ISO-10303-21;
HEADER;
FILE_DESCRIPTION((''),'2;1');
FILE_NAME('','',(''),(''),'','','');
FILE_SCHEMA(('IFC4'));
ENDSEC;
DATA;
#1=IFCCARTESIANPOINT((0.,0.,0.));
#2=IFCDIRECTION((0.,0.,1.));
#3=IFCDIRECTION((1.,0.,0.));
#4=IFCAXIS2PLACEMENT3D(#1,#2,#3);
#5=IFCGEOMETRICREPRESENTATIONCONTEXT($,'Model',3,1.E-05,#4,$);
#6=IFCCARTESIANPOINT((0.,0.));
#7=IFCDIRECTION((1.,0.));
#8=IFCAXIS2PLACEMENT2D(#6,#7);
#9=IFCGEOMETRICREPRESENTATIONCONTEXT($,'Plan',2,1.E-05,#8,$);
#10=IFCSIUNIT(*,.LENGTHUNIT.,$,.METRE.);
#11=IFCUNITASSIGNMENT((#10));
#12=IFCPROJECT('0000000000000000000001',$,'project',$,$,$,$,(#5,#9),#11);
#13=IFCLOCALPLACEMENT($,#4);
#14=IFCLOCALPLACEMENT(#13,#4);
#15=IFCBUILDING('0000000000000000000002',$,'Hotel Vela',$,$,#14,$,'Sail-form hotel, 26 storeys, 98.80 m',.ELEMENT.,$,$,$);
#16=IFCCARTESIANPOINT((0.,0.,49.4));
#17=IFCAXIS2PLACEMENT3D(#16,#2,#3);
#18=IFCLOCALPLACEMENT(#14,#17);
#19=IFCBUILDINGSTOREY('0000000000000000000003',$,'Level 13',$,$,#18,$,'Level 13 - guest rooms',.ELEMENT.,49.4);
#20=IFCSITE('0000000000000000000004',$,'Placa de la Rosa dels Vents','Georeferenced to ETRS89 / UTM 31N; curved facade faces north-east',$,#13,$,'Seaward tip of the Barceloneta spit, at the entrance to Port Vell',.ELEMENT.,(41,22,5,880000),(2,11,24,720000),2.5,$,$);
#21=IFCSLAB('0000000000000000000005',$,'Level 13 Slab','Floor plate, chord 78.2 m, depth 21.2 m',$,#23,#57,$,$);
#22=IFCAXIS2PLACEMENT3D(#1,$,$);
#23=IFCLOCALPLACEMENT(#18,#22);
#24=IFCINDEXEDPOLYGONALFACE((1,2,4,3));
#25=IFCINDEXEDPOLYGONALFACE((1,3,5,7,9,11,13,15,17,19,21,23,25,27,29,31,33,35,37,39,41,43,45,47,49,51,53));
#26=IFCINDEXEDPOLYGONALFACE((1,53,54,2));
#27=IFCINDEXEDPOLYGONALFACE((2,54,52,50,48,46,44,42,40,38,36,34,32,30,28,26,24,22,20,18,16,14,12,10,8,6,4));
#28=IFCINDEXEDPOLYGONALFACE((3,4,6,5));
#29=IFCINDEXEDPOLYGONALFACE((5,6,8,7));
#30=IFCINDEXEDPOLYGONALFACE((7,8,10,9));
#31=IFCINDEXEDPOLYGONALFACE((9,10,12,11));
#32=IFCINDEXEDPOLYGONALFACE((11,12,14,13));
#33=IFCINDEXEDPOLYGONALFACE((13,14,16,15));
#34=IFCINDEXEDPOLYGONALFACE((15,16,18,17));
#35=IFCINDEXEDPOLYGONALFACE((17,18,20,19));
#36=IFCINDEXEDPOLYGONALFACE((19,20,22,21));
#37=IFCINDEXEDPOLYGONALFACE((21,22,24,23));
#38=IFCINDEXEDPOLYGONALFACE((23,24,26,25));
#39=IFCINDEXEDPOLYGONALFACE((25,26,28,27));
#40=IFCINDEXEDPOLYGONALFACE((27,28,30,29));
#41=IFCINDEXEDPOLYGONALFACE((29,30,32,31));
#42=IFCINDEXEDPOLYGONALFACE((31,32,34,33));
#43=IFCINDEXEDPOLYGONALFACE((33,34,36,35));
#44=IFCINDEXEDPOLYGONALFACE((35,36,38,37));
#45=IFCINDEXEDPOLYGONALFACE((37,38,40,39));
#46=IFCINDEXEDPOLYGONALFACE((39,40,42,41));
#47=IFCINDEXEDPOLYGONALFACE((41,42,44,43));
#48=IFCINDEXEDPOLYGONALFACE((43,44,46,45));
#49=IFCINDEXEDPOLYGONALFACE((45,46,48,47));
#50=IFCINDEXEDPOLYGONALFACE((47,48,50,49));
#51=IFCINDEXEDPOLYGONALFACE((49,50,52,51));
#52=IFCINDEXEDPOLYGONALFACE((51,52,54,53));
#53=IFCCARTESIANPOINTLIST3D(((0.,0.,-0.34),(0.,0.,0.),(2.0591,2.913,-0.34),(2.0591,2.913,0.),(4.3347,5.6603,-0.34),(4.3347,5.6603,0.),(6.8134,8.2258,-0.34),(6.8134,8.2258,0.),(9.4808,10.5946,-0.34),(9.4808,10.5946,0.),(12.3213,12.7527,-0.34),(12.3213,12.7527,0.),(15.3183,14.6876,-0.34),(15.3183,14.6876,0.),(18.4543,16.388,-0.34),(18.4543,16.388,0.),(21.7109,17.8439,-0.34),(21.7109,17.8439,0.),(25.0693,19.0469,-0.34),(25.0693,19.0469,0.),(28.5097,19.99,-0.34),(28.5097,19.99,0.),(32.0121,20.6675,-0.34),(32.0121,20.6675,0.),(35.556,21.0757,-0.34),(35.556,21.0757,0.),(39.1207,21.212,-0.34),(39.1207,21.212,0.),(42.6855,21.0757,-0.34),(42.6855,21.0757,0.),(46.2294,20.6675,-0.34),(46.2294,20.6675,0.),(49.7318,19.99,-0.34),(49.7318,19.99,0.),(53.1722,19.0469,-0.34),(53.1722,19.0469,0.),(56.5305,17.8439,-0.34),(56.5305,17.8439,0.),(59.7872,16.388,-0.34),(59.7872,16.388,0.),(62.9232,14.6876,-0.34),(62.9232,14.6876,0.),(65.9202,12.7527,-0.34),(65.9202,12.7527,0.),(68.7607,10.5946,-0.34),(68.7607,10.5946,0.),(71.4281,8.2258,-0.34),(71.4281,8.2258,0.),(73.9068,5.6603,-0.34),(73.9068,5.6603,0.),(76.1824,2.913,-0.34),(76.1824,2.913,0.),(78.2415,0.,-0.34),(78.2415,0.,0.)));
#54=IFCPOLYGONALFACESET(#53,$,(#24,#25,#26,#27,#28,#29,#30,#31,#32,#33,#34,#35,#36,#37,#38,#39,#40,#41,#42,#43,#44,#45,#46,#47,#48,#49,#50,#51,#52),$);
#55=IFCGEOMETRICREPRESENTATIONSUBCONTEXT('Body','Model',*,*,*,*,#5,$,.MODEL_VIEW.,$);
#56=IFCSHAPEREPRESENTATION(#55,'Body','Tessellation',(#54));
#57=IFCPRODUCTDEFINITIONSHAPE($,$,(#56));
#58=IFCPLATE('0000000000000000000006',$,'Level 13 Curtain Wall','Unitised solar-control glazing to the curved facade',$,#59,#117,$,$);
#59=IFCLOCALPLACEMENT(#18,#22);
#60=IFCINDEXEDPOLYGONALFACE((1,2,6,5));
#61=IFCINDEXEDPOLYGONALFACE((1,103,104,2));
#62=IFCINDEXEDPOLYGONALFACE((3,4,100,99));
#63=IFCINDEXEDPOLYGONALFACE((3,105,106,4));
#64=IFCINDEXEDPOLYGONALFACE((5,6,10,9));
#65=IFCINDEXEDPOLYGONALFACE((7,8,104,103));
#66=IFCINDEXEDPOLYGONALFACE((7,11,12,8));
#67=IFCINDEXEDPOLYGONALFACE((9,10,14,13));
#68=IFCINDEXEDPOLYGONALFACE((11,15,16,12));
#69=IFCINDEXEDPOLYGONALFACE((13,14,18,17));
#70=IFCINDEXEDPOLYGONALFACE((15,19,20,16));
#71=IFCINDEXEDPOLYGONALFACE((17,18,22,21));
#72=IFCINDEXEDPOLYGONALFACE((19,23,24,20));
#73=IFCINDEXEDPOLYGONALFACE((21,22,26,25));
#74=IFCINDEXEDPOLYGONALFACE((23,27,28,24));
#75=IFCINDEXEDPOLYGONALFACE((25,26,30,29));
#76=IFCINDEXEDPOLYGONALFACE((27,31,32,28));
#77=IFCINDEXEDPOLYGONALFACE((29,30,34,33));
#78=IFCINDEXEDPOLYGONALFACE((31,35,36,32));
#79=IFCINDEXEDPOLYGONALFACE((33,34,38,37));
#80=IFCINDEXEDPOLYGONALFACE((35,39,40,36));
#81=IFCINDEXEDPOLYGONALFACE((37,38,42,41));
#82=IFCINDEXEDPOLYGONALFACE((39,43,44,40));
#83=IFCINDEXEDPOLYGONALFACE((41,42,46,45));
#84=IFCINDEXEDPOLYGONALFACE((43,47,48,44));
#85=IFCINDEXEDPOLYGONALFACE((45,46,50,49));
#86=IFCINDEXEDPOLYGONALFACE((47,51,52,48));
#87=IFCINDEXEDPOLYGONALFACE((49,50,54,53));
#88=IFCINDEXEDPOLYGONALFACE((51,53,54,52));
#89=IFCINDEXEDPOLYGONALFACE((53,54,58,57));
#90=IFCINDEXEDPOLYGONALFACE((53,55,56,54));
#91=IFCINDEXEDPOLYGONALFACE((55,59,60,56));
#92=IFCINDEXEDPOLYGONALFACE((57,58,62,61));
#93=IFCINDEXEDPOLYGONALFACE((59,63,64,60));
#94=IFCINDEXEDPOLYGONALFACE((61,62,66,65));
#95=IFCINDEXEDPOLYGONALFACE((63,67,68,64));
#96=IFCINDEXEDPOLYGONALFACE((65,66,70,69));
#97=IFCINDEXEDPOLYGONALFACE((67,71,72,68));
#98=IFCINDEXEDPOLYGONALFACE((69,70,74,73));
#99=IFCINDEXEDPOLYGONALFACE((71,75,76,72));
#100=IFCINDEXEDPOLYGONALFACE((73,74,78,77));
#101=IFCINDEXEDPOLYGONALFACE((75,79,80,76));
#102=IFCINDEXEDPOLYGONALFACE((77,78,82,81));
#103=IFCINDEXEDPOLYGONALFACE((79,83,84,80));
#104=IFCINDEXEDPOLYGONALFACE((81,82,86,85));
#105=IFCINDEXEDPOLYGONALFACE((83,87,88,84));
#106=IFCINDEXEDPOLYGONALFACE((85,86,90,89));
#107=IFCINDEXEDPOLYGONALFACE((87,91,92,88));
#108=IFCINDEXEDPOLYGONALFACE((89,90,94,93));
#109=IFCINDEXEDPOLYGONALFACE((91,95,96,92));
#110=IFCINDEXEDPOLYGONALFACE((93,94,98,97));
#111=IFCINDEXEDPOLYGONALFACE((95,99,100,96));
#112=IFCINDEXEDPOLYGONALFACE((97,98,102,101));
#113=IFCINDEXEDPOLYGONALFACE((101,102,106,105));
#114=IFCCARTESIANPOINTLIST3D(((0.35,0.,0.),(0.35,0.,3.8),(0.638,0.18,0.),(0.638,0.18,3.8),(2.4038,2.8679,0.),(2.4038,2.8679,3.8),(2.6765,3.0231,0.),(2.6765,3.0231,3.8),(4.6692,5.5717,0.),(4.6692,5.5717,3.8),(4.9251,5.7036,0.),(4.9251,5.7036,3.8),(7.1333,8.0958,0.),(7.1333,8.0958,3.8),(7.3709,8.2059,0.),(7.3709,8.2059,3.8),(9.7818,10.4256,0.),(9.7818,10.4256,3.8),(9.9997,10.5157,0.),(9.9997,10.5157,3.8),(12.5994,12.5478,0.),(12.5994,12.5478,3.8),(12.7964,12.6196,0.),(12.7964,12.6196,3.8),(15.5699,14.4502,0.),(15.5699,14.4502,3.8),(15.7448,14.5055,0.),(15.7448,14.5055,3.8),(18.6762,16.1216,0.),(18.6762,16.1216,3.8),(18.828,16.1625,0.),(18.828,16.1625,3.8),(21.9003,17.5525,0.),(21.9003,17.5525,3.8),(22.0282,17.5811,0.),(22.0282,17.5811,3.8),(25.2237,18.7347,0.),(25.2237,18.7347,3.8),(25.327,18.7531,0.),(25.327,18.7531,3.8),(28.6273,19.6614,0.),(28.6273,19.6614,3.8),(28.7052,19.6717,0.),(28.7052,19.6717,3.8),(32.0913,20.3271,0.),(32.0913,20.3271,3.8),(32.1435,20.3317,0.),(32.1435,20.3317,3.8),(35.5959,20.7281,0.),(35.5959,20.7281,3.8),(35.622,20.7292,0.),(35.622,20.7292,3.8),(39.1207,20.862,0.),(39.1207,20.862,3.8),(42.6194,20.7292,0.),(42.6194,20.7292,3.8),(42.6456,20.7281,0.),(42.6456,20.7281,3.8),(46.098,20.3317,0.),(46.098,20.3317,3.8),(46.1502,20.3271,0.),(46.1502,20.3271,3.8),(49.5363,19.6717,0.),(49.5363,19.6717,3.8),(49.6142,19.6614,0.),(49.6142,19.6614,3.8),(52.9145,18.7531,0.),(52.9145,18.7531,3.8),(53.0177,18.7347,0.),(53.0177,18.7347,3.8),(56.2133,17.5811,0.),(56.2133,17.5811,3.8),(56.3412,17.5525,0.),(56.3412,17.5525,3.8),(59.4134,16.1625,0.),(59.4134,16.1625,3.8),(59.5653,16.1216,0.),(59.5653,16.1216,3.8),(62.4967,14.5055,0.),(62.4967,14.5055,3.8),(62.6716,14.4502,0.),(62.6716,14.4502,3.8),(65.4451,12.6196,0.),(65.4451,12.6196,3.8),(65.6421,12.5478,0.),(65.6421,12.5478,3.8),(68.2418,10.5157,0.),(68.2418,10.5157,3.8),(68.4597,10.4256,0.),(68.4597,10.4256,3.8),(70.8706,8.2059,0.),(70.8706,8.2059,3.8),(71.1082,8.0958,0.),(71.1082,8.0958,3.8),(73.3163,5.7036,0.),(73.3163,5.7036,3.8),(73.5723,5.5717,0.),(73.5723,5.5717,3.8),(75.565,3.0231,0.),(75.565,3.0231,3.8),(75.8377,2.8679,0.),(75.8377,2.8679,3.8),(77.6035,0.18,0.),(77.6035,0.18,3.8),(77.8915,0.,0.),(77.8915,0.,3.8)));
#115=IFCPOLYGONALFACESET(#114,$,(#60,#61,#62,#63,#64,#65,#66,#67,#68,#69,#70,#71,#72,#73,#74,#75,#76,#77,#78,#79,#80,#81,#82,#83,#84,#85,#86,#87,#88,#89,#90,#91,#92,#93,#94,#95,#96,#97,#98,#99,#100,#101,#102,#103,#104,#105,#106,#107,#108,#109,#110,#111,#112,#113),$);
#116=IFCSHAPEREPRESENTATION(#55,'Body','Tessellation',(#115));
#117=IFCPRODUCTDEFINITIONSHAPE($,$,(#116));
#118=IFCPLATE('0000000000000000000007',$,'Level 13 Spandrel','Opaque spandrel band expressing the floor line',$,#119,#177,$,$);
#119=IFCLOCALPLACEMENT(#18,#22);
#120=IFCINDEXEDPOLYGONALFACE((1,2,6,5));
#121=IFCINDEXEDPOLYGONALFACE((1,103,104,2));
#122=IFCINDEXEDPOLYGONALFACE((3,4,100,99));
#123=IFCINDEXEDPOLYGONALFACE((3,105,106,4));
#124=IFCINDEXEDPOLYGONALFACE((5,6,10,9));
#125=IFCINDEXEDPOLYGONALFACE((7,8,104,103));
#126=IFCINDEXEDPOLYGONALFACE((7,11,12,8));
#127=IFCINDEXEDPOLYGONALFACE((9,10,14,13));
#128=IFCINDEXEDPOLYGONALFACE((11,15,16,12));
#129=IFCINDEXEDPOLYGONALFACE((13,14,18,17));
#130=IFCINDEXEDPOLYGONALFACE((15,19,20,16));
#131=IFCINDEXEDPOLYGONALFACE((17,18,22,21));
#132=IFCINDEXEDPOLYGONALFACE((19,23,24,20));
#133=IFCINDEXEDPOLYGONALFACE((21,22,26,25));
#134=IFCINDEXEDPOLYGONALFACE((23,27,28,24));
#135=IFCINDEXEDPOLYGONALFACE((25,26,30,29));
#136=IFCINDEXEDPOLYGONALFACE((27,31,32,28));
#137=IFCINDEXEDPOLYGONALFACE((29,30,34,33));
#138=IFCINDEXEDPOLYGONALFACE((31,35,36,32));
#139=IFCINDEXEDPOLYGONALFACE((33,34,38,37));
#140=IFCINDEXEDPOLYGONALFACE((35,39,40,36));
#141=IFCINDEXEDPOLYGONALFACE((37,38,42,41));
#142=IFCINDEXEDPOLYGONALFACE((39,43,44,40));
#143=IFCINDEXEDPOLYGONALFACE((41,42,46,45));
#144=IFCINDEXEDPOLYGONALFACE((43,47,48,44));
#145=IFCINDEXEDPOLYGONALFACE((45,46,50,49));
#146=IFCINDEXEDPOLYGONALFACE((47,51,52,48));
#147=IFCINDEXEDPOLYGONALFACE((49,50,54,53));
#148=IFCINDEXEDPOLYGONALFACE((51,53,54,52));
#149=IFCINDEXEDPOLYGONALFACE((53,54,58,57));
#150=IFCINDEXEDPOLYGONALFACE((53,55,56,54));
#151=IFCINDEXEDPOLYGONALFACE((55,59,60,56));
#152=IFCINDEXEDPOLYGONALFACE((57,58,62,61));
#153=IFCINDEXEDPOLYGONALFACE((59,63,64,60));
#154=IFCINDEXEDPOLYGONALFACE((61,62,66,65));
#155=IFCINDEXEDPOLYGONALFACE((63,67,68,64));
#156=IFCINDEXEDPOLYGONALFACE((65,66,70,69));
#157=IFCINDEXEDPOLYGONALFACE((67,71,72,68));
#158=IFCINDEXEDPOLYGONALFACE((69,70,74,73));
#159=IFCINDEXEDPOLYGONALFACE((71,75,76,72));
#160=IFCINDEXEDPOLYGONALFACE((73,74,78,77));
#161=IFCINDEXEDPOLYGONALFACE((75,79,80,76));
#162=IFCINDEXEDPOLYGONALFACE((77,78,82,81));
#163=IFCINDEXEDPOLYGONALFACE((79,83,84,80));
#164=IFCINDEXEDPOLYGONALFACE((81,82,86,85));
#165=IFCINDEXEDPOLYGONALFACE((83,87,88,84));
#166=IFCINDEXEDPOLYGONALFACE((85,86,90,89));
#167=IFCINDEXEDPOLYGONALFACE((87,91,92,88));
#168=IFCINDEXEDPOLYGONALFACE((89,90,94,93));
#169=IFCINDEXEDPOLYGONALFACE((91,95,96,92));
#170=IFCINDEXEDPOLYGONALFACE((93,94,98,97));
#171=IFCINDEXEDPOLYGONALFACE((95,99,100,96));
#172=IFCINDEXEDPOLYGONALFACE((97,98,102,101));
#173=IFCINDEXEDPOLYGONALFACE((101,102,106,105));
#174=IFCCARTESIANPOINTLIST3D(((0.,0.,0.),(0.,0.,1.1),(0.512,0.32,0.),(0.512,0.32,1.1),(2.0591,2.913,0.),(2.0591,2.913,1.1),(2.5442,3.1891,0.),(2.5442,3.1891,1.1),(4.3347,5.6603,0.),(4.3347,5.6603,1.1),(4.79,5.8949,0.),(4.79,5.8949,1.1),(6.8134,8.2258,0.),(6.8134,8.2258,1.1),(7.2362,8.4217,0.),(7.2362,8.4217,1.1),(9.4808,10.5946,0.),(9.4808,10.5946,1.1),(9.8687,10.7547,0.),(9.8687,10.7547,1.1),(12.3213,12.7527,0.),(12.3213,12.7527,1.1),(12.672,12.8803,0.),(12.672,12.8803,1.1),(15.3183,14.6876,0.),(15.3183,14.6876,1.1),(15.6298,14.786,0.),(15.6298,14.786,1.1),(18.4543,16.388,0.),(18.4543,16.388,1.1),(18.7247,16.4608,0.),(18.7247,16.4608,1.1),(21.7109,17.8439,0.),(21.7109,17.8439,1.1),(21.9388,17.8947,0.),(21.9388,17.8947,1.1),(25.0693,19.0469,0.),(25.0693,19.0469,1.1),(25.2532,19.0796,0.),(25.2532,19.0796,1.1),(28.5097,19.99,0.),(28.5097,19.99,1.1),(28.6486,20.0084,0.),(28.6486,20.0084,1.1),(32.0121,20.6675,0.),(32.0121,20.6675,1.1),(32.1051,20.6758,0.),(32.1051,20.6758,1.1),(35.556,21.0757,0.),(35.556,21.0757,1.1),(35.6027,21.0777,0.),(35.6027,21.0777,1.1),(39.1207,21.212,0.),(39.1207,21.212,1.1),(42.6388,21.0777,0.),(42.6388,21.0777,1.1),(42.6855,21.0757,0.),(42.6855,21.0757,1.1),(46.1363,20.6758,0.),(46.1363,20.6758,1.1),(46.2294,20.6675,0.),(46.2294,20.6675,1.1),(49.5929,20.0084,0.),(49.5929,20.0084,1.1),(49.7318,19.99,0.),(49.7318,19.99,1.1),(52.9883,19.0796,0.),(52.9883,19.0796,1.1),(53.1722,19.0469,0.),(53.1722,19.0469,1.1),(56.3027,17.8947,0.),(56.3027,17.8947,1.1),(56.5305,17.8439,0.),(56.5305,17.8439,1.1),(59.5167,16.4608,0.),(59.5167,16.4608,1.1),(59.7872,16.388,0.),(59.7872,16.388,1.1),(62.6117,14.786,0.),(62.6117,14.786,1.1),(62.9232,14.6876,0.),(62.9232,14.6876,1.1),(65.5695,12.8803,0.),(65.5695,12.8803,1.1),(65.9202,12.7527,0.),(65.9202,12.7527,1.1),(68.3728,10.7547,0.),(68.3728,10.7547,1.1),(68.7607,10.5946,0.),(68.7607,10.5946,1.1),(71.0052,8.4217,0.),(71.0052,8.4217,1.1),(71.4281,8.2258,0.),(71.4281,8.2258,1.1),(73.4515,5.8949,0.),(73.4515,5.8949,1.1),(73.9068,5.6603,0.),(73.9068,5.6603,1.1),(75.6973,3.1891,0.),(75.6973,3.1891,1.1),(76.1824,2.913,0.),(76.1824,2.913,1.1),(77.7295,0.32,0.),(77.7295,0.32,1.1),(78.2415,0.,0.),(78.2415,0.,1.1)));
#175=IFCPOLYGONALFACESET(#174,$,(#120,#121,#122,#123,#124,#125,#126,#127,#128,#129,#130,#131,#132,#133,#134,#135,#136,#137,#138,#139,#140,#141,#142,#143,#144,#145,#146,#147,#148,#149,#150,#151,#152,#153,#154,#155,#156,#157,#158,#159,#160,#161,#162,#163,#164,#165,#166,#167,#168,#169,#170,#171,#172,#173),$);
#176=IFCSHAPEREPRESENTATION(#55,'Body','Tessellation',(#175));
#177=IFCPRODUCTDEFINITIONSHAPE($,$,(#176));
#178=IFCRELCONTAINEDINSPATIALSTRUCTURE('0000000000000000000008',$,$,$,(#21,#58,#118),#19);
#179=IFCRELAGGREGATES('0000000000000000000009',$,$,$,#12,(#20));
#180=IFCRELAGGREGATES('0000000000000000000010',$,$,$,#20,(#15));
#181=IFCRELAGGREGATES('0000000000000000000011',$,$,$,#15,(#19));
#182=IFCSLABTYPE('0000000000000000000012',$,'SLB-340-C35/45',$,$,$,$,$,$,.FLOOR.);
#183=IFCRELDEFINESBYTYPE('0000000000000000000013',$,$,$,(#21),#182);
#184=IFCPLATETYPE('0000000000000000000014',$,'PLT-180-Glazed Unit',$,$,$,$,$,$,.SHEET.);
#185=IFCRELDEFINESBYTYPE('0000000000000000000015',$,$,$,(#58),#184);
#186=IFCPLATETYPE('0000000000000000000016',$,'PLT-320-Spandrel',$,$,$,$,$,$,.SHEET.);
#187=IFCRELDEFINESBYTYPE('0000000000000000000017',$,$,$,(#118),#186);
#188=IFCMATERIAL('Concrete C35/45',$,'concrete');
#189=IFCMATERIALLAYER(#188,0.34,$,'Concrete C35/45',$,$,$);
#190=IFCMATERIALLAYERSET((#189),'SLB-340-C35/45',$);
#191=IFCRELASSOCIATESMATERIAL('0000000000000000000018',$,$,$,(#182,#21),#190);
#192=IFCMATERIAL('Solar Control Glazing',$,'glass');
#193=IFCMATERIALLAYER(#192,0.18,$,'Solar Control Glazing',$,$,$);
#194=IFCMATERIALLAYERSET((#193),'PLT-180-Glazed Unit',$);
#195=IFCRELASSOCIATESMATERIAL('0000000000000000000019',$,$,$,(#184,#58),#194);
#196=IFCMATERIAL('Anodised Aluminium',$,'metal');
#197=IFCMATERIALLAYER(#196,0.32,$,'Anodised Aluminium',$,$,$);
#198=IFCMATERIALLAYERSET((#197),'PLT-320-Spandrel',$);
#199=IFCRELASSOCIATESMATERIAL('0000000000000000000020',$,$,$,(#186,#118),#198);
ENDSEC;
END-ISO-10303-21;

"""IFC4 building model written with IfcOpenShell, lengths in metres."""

from ifc_helpers import new_model, si_unit, frame, origin_with_axes, origin_2d_with_axis, place, context, subcontext, project, spatial, line, indexed_curve, outline, extrude, material, layer, layer_set, layer_usage, type_object, element, save


model = new_model("IFC4")

# Units and contexts
model_context = context("Model", 3, precision=1e-05, world=origin_with_axes())
plan_context = context("Plan", 2, precision=1e-05, world=origin_2d_with_axis())
body_context = subcontext(model_context, "Body", "Model", "MODEL_VIEW")
ifc_project = project(units=[si_unit("LENGTHUNIT", "METRE")], contexts=[model_context, plan_context])

# Site, building, storey
site_placement = place(None, origin_with_axes())
site = spatial("IfcSite", under=ifc_project, at=site_placement, Name="Placa de la Rosa dels Vents", Description="Georeferenced to ETRS89 / UTM 31N; curved facade faces north-east", LongName="Seaward tip of the Barceloneta spit, at the entrance to Port Vell", CompositionType="ELEMENT", RefLatitude=(41, 22, 5, 880000), RefLongitude=(2, 11, 24, 720000), RefElevation=2.5)
building_placement = place(site_placement, origin_with_axes())
building = spatial("IfcBuilding", under=site, at=building_placement, Name="Hotel Vela", LongName="Sail-form hotel, 26 storeys, 98.80 m", CompositionType="ELEMENT")
storey_placement = place(building_placement, frame((0.0, 0.0, 49.4), z_axis=(0.0, 0.0, 1.0), x_axis=(1.0, 0.0, 0.0)))
storey = spatial("IfcBuildingStorey", under=building, at=storey_placement, Name="Level 13", LongName="Level 13 - guest rooms", CompositionType="ELEMENT", Elevation=49.4)

# Slab
ifc_material_1 = material(Name="Concrete C35/45", Category="concrete")
ifc_layer_1 = layer(ifc_material_1, 0.34, Name="Concrete C35/45")
ifc_layer_set_1 = layer_set([ifc_layer_1], Name="SLB-340-C35/45")
ifc_layer_usage_1 = layer_usage(ifc_layer_set_1, "AXIS3", "POSITIVE", 0.0)
slab_type = type_object("IfcSlabType", Name="SLB-340-C35/45", PredefinedType="FLOOR", material=ifc_layer_set_1)
slab_placement = place(storey_placement, frame((0.0, 0.0, -0.34), z_axis=(0.0, 0.0, 1.0), x_axis=(1.0, 0.0, 0.0)))
element("IfcSlab", 1, at=slab_placement, inside=storey, type_object=slab_type, material=ifc_layer_usage_1, Name="Level 13 Slab", Description="Floor plate, chord 78.2 m, depth 21.2 m", context=body_context, shape_type="SweptSolid", body=[
    extrude(outline(indexed_curve([(0.0, 0.0), (78.2415, 0.0), (76.1824, 2.913), (73.9068, 5.6603), (71.4281, 8.2258), (68.7607, 10.5946), (65.9202, 12.7527), (62.9232, 14.6876), (59.7872, 16.388), (56.5305, 17.8439), (53.1722, 19.0469), (49.7318, 19.99), (46.2294, 20.6675), (42.6855, 21.0757), (39.1207, 21.212), (35.556, 21.0757), (32.0121, 20.6675), (28.5097, 19.99), (25.0693, 19.0469), (21.7109, 17.8439), (18.4543, 16.388), (15.3183, 14.6876), (12.3213, 12.7527), (9.4808, 10.5946), (6.8134, 8.2258), (4.3347, 5.6603), (2.0591, 2.913)], segments=[line(1, 2, 3, 4, 5, 6, 7, 8, 9, 10, 11, 12, 13, 14, 15, 16, 17, 18, 19, 20, 21, 22, 23, 24, 25, 26, 27, 1)])), origin_with_axes(), (0.0, 0.0, 1.0), 0.34),
])

# Plates
ifc_material_2 = material(Name="Solar Control Glazing", Category="glass")
ifc_layer_2 = layer(ifc_material_2, 0.18, Name="Solar Control Glazing")
ifc_layer_set_2 = layer_set([ifc_layer_2], Name="PLT-180-Glazed Unit")
ifc_layer_usage_2 = layer_usage(ifc_layer_set_2, "AXIS2", "POSITIVE", 0.0)
plate_type_1 = type_object("IfcPlateType", Name="PLT-180-Glazed Unit", PredefinedType="SHEET", material=ifc_layer_set_2)
plate_1_placement = place(storey_placement, frame((0.35, 0.0, 0.0), z_axis=(0.0, 0.0, 1.0), x_axis=(1.0, 0.0, 0.0)))
element("IfcPlate", 2, at=plate_1_placement, inside=storey, type_object=plate_type_1, material=ifc_layer_usage_2, Name="Level 13 Curtain Wall", Description="Unitised solar-control glazing to the curved facade", context=body_context, shape_type="SweptSolid", body=[
    extrude(outline(indexed_curve([(77.5415, 0.0), (75.4877, 2.8679), (73.2223, 5.5717), (70.7582, 8.0958), (68.1097, 10.4256), (65.2921, 12.5478), (62.3216, 14.4502), (59.2153, 16.1216), (55.9912, 17.5525), (52.6677, 18.7347), (49.2642, 19.6614), (45.8002, 20.3271), (42.2956, 20.7281), (38.7707, 20.862), (35.2459, 20.7281), (31.7413, 20.3271), (28.2773, 19.6614), (24.8737, 18.7347), (21.5503, 17.5525), (18.3262, 16.1216), (15.2199, 14.4502), (12.2494, 12.5478), (9.4318, 10.4256), (6.7833, 8.0958), (4.3192, 5.5717), (2.0538, 2.8679), (0.0, 0.0), (77.2535, 0.18), (2.3265, 3.0231), (4.5751, 5.7036), (7.0209, 8.2059), (9.6497, 10.5157), (12.4464, 12.6196), (15.3948, 14.5055), (18.478, 16.1625), (21.6782, 17.5811), (24.977, 18.7531), (28.3552, 19.6717), (31.7935, 20.3317), (35.272, 20.7292), (38.7707, 20.862), (42.2694, 20.7292), (45.748, 20.3317), (49.1863, 19.6717), (52.5645, 18.7531), (55.8633, 17.5811), (59.0634, 16.1625), (62.1467, 14.5055), (65.0951, 12.6196), (67.8918, 10.5157), (70.5206, 8.2059), (72.9663, 5.7036), (75.215, 3.0231), (0.288, 0.18)], segments=[line(1, 2, 3, 4, 5, 6, 7, 8, 9, 10, 11, 12, 13, 14, 15, 16, 17, 18, 19, 20, 21, 22, 23, 24, 25, 26, 27, 28, 29, 30, 31, 32, 33, 34, 35, 36, 37, 38, 39, 40, 41, 42, 43, 44, 45, 46, 47, 48, 49, 50, 51, 52, 53, 54, 1)])), origin_with_axes(), (0.0, 0.0, 1.0), 3.8),
])
ifc_material_3 = material(Name="Anodised Aluminium", Category="metal")
ifc_layer_3 = layer(ifc_material_3, 0.32, Name="Anodised Aluminium")
ifc_layer_set_3 = layer_set([ifc_layer_3], Name="PLT-320-Spandrel")
ifc_layer_usage_3 = layer_usage(ifc_layer_set_3, "AXIS2", "POSITIVE", 0.0)
plate_type_2 = type_object("IfcPlateType", Name="PLT-320-Spandrel", PredefinedType="SHEET", material=ifc_layer_set_3)
plate_2_placement = place(storey_placement, origin_with_axes())
element("IfcPlate", 3, at=plate_2_placement, inside=storey, type_object=plate_type_2, material=ifc_layer_usage_3, Name="Level 13 Spandrel", Description="Opaque spandrel band expressing the floor line", context=body_context, shape_type="SweptSolid", body=[
    extrude(outline(indexed_curve([(78.2415, 0.0), (76.1824, 2.913), (73.9068, 5.6603), (71.4281, 8.2258), (68.7607, 10.5946), (65.9202, 12.7527), (62.9232, 14.6876), (59.7872, 16.388), (56.5305, 17.8439), (53.1722, 19.0469), (49.7318, 19.99), (46.2294, 20.6675), (42.6855, 21.0757), (39.1207, 21.212), (35.556, 21.0757), (32.0121, 20.6675), (28.5097, 19.99), (25.0693, 19.0469), (21.7109, 17.8439), (18.4543, 16.388), (15.3183, 14.6876), (12.3213, 12.7527), (9.4808, 10.5946), (6.8134, 8.2258), (4.3347, 5.6603), (2.0591, 2.913), (0.0, 0.0), (77.7295, 0.32), (2.5442, 3.1891), (4.79, 5.8949), (7.2362, 8.4217), (9.8687, 10.7547), (12.672, 12.8803), (15.6298, 14.786), (18.7247, 16.4608), (21.9388, 17.8947), (25.2532, 19.0796), (28.6486, 20.0084), (32.1051, 20.6758), (35.6027, 21.0777), (39.1207, 21.212), (42.6388, 21.0777), (46.1363, 20.6758), (49.5929, 20.0084), (52.9883, 19.0796), (56.3027, 17.8947), (59.5167, 16.4608), (62.6117, 14.786), (65.5695, 12.8803), (68.3728, 10.7547), (71.0052, 8.4217), (73.4515, 5.8949), (75.6973, 3.1891), (0.512, 0.32)], segments=[line(1, 2, 3, 4, 5, 6, 7, 8, 9, 10, 11, 12, 13, 14, 15, 16, 17, 18, 19, 20, 21, 22, 23, 24, 25, 26, 27, 28, 29, 30, 31, 32, 33, 34, 35, 36, 37, 38, 39, 40, 41, 42, 43, 44, 45, 46, 47, 48, 49, 50, 51, 52, 53, 54, 1)])), origin_with_axes(), (0.0, 0.0, 1.0), 1.1),
])

save(model, "model.ifc")
